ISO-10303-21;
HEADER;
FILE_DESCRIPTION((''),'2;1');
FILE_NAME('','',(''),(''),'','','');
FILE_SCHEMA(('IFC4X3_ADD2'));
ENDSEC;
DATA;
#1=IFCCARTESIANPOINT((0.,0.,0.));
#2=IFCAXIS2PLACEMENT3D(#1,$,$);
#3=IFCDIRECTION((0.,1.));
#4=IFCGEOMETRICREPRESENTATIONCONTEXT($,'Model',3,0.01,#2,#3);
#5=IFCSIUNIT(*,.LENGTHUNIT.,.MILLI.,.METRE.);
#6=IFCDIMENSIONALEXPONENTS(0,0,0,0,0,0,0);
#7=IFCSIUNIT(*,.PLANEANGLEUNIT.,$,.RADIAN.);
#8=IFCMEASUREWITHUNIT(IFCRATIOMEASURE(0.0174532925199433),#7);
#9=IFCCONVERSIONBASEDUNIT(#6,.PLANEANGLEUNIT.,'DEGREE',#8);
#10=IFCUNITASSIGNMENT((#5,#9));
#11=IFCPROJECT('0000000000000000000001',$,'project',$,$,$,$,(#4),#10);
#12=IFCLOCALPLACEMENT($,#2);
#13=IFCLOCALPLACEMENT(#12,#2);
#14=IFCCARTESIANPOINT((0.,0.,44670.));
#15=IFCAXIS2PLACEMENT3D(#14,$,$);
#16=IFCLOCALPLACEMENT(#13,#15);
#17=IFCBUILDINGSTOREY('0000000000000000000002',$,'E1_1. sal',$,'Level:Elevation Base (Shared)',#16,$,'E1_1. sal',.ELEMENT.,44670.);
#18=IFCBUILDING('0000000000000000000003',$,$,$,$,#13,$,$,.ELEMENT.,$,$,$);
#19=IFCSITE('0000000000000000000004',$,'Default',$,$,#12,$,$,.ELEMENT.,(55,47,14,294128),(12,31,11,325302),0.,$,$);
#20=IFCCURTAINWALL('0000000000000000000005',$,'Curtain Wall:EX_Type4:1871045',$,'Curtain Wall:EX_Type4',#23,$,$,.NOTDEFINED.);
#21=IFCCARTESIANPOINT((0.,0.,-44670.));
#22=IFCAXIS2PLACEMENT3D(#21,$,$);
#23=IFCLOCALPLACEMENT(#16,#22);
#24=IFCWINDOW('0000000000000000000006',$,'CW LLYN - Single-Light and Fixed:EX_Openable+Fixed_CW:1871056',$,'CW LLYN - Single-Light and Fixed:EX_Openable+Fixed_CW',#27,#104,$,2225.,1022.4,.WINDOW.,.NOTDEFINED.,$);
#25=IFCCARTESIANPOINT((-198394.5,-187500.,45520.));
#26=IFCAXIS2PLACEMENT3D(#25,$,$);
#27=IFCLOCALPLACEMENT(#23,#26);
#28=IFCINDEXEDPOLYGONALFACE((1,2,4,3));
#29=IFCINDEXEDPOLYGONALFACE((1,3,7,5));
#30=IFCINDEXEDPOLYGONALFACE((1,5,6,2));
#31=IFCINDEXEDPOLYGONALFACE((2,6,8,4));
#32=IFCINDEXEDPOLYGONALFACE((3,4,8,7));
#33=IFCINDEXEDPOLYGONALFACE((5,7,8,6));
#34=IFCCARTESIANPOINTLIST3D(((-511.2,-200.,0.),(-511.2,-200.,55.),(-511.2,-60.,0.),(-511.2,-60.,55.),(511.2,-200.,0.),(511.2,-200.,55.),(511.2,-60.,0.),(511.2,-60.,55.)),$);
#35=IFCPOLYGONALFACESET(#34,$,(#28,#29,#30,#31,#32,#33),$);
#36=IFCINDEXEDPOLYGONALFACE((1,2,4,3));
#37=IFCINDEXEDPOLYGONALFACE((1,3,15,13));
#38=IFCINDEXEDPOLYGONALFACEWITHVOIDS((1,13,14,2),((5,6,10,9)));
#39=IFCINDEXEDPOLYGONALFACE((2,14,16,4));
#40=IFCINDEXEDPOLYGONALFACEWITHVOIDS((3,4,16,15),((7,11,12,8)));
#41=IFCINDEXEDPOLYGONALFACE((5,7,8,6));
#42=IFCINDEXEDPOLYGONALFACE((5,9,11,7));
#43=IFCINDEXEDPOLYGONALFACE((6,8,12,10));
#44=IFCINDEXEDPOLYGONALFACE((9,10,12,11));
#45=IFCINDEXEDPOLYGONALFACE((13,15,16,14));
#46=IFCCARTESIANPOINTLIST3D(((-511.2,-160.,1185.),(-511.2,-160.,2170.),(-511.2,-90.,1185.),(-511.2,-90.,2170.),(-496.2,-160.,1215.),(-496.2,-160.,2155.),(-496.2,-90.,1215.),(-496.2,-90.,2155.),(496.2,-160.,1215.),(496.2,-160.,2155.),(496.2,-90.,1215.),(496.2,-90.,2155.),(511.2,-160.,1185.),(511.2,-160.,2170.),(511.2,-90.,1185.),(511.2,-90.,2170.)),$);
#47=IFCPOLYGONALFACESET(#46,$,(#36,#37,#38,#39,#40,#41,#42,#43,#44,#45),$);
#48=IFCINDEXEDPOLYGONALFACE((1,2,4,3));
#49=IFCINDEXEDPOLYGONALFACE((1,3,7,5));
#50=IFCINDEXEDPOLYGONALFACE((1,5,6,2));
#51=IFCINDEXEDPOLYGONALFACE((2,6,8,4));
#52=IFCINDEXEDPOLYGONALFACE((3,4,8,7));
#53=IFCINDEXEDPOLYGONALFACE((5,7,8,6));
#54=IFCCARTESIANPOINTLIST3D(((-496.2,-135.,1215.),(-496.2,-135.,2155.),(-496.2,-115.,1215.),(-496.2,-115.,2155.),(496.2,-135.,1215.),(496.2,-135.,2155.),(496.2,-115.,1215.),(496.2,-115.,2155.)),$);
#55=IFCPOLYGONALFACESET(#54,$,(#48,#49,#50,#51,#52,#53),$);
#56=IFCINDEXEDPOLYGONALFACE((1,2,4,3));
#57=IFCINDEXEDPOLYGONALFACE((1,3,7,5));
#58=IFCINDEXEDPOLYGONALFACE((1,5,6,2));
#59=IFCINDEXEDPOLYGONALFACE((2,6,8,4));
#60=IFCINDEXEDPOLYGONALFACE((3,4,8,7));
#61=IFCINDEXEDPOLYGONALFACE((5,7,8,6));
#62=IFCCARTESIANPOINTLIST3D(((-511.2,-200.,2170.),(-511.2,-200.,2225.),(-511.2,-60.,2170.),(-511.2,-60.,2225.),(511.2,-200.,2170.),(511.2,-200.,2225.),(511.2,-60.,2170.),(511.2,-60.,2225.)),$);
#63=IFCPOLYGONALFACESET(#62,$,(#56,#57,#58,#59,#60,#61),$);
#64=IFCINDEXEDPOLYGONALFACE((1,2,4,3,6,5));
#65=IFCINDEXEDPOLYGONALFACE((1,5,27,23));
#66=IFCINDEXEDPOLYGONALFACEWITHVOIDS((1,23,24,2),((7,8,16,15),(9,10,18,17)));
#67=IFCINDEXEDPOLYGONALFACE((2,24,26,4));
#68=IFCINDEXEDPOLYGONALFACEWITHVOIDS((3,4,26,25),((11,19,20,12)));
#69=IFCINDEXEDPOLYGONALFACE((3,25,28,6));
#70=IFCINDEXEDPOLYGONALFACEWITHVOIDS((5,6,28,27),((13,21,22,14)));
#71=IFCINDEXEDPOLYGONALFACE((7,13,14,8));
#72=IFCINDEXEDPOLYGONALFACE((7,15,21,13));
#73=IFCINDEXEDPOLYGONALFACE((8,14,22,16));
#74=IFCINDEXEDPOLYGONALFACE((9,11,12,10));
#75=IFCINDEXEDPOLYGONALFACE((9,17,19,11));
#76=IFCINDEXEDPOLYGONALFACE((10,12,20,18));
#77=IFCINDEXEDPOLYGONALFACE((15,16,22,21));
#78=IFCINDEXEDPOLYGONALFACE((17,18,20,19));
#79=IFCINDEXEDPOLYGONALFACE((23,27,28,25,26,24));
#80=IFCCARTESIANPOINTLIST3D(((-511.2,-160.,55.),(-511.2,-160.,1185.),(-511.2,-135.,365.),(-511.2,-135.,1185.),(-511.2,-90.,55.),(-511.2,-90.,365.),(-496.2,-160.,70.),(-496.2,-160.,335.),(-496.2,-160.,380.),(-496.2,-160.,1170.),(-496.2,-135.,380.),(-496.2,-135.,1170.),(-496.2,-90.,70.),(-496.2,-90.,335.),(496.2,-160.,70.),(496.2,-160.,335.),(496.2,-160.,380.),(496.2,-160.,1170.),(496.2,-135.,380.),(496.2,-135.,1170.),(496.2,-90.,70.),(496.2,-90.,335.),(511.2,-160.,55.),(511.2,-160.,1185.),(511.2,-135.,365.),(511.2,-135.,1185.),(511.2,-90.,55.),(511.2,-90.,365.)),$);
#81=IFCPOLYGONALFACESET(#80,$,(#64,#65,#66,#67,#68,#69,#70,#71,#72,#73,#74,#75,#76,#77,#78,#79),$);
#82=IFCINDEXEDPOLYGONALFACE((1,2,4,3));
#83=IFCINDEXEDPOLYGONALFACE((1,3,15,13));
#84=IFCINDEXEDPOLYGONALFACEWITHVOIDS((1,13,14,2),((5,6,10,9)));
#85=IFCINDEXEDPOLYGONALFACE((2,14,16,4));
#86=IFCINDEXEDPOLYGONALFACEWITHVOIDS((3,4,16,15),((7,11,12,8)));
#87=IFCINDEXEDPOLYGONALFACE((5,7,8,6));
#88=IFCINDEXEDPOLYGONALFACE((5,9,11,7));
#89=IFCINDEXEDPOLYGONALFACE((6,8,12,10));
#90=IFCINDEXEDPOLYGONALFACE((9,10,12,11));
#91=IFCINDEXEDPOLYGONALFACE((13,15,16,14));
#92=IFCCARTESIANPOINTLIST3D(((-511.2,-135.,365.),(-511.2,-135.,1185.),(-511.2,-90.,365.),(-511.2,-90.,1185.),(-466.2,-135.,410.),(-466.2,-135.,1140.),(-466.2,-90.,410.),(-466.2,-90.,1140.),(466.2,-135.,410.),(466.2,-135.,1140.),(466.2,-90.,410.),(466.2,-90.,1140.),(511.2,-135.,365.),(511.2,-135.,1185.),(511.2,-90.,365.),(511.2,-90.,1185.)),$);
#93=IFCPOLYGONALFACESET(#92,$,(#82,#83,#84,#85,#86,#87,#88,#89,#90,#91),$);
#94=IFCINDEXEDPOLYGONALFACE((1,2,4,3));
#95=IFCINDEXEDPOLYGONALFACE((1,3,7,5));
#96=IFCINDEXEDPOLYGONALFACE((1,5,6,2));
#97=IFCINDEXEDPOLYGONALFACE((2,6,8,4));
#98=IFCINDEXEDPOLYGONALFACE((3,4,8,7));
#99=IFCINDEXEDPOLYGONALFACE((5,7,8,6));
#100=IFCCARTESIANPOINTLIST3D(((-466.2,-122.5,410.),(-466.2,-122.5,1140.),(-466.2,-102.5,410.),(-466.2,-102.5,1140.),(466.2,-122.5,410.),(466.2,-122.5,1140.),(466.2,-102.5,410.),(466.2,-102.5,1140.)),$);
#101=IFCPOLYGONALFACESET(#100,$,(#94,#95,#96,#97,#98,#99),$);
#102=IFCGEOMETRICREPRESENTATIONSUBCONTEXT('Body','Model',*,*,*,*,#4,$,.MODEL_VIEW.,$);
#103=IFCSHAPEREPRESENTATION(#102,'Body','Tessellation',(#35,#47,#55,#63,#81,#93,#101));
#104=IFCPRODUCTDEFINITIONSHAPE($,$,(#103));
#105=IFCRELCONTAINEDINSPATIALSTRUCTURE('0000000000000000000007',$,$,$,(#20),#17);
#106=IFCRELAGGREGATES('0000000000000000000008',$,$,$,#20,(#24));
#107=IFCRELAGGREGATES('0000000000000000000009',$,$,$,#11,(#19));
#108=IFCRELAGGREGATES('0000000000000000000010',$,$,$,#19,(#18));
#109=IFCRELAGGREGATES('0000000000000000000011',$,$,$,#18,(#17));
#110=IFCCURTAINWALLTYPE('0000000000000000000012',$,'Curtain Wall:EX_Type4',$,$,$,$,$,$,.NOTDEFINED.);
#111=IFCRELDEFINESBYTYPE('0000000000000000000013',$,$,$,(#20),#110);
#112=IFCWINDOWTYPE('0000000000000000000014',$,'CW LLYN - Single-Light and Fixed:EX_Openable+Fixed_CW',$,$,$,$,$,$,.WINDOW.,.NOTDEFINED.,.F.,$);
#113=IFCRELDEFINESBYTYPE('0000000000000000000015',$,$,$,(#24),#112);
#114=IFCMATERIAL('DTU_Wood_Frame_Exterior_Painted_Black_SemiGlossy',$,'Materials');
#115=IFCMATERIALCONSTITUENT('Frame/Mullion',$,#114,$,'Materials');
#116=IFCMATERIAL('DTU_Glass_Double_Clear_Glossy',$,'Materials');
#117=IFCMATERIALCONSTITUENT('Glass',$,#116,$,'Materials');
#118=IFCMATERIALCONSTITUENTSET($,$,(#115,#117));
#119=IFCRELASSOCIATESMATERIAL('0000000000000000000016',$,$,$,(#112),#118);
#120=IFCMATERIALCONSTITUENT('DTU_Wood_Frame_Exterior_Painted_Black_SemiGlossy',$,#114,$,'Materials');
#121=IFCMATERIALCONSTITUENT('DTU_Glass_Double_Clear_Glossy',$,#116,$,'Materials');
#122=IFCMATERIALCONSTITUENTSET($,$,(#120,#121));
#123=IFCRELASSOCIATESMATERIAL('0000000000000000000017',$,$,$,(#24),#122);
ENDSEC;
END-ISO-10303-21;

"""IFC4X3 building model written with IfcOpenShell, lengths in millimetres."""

from ifc_helpers import new_model, entity, si_unit, converted_unit, direction, frame, frame_2d, origin, origin_2d_with_axis, place, context, subcontext, project, spatial, polyline, rectangle, outline, extrude, source, transform, mapped, material, constituent, constituent_set, type_object, type_shapes, element, aggregate, save


model = new_model("IFC4X3")

# Units and contexts
model_context = context("Model", 3, precision=0.01, world=origin(), true_north=direction((0.0, 1.0)))
body_context = subcontext(model_context, "Body", "Model", "MODEL_VIEW")
ifc_project = project(units=[si_unit("LENGTHUNIT", "METRE", prefix="MILLI"), converted_unit("PLANEANGLEUNIT", "DEGREE", entity("IfcRatioMeasure", 0.0174532925199433), si_unit("PLANEANGLEUNIT", "RADIAN"), dimensions=[0, 0, 0, 0, 0, 0, 0])], contexts=[model_context])

# Site, building, storey
site_placement = place(None, origin())
site = spatial("IfcSite", under=ifc_project, at=site_placement, Name="Default", CompositionType="ELEMENT", RefLatitude=(55, 47, 14, 294128), RefLongitude=(12, 31, 11, 325302), RefElevation=0.0)
building_placement = place(site_placement, origin())
building = spatial("IfcBuilding", under=site, at=building_placement, CompositionType="ELEMENT")
storey_placement = place(building_placement, frame((0.0, 0.0, 44670.0)))
storey = spatial("IfcBuildingStorey", under=building, at=storey_placement, Name="E1_1. sal", ObjectType="Level:Elevation Base (Shared)", LongName="E1_1. sal", CompositionType="ELEMENT", Elevation=44670.0)

# Curtain wall
curtain_wall_type_1 = type_object("IfcCurtainWallType", Name="Curtain Wall:EX_Type4", PredefinedType="NOTDEFINED")
curtain_wall_1_placement = place(storey_placement, frame((0.0, 0.0, -44670.0)))
curtain_wall_1 = element("IfcCurtainWall", 1, at=curtain_wall_1_placement, inside=storey, type_object=curtain_wall_type_1, Name="Curtain Wall:EX_Type4:1871045", ObjectType="Curtain Wall:EX_Type4", PredefinedType="NOTDEFINED")

# Shared definitions
ifc_material_1 = material(Name="DTU_Wood_Frame_Exterior_Painted_Black_SemiGlossy", Category="Materials")
ifc_material_2 = material(Name="DTU_Glass_Double_Clear_Glossy", Category="Materials")

# Window, openings
ifc_constituent_1 = constituent(ifc_material_1, Name="DTU_Wood_Frame_Exterior_Painted_Black_SemiGlossy", Category="Materials")
ifc_constituent_2 = constituent(ifc_material_2, Name="DTU_Glass_Double_Clear_Glossy", Category="Materials")
ifc_constituent_set_1 = constituent_set(constituents=[ifc_constituent_1, ifc_constituent_2])
ifc_constituent_3 = constituent(ifc_material_1, Name="Frame/Mullion", Category="Materials")
ifc_constituent_4 = constituent(ifc_material_2, Name="Glass", Category="Materials")
ifc_constituent_set_2 = constituent_set(constituents=[ifc_constituent_3, ifc_constituent_4])
window_type_1 = type_object("IfcWindowType", Name="CW LLYN - Single-Light and Fixed:EX_Openable+Fixed_CW", ParameterTakesPrecedence=False, PartitioningType="NOTDEFINED", PredefinedType="WINDOW", material=ifc_constituent_set_2)
shared_shape_1 = source(origin(), body_context, "Body", "SweptSolid", [
    extrude(rectangle(XDim=140.0, YDim=1022.4, at=origin_2d_with_axis()), frame((0.0, -130.0, 0.0), z_axis=(0.0, 0.0, 1.0), x_axis=(0.0, -1.0, 0.0)), (0.0, 0.0, 1.0), 55.0),
    extrude(outline(polyline([(-492.5, -511.2), (492.5, -511.2), (492.5, 511.2), (-492.5, 511.2), (-492.5, -511.2)]), holes=[polyline([(477.5, -496.2), (-462.5, -496.2), (-462.5, 496.2), (477.5, 496.2), (477.5, -496.2)])]), frame((0.0, -90.0, 1677.5), z_axis=(0.0, -1.0, 0.0), x_axis=(0.0, 0.0, 1.0)), (0.0, 0.0, 1.0), 70.0),
    extrude(rectangle(XDim=992.4, YDim=20.0, at=frame_2d((0.0, 0.0), x_axis=(1.0, 0.0))), frame((0.0, -125.0, 1215.0), z_axis=(0.0, 0.0, 1.0), x_axis=(-1.0, 0.0, 0.0)), (0.0, 0.0, 1.0), 940.0),
    extrude(rectangle(XDim=992.4, YDim=20.0, at=frame_2d((0.0, 0.0), x_axis=(1.0, 0.0))), frame((0.0, -125.0, 70.0), z_axis=(0.0, 0.0, 1.0), x_axis=(-1.0, 0.0, 0.0)), (0.0, 0.0, 1.0), 265.0),
    extrude(rectangle(XDim=140.0, YDim=1022.4, at=frame_2d((0.0, 0.0), x_axis=(1.0, 0.0))), frame((0.0, -130.0, 2170.0), z_axis=(0.0, 0.0, 1.0), x_axis=(0.0, -1.0, 0.0)), (0.0, 0.0, 1.0), 55.0),
    extrude(outline(polyline([(-38.3, -480.0), (31.7, -480.0), (31.7, 650.0), (6.7, 650.0), (6.7, -170.0), (-38.3, -170.0), (-38.3, -480.0)])), frame((511.2, -128.3, 535.0), z_axis=(-1.0, 0.0, 0.0), x_axis=(0.0, -1.0, 0.0)), (0.0, 0.0, 1.0), 1022.4),
    extrude(outline(polyline([(-410.0, -511.2), (410.0, -511.2), (410.0, 511.2), (-410.0, 511.2), (-410.0, -511.2)]), holes=[polyline([(-365.0, 466.2), (365.0, 466.2), (365.0, -466.2), (-365.0, -466.2), (-365.0, 466.2)])]), frame((0.0, -90.0, 775.0), z_axis=(0.0, -1.0, 0.0), x_axis=(0.0, 0.0, 1.0)), (0.0, 0.0, 1.0), 45.0),
    extrude(rectangle(XDim=932.4, YDim=20.0, at=frame_2d((0.0, 0.0), x_axis=(1.0, 0.0))), frame((0.0, -112.5, 410.0), z_axis=(0.0, 0.0, 1.0), x_axis=(-1.0, 0.0, 0.0)), (0.0, 0.0, 1.0), 730.0),
])
type_shapes(window_type_1, [shared_shape_1])
window_1_placement = place(curtain_wall_1_placement, frame((-198394.5, -187500.0, 45520.0)))
window_1 = element("IfcWindow", 2, at=window_1_placement, type_object=window_type_1, material=ifc_constituent_set_1, Name="CW LLYN - Single-Light and Fixed:EX_Openable+Fixed_CW:1871056", ObjectType="CW LLYN - Single-Light and Fixed:EX_Openable+Fixed_CW", OverallHeight=2225.0, OverallWidth=1022.4, PartitioningType="NOTDEFINED", PredefinedType="WINDOW", context=body_context, shape_type="MappedRepresentation", body=[
    mapped(shared_shape_1, transform((0.0, 0.0, 0.0), scale=1.0)),
])
opening_1_placement = place(curtain_wall_1_placement, frame((-198394.5, -187500.0, 90190.0), z_axis=(0.0, 0.0, 1.0), x_axis=(-1.0, 0.0, 0.0)))
opening_1 = element("IfcOpeningElement", 3, at=opening_1_placement, cuts=window_1, PredefinedType="OPENING", context=body_context, shape_type="SweptSolid", body=[
    extrude(rectangle(XDim=265.0, YDim=992.4, at=frame_2d((0.0, 0.0), x_axis=(1.0, 0.0))), frame((0.0, 160.0, -44467.5), z_axis=(0.0, -1.0, 0.0), x_axis=(0.0, 0.0, 1.0)), (0.0, 0.0, 1.0), 70.0),
])
opening_2_placement = place(curtain_wall_1_placement, frame((-198394.5, -187500.0, 90190.0), z_axis=(0.0, 0.0, 1.0), x_axis=(-1.0, 0.0, 0.0)))
opening_2 = element("IfcOpeningElement", 4, at=opening_2_placement, cuts=window_1, PredefinedType="OPENING", context=body_context, shape_type="SweptSolid", body=[
    extrude(rectangle(XDim=790.0, YDim=992.4, at=frame_2d((0.0, 0.0), x_axis=(1.0, 0.0))), frame((0.0, 135.0, -43895.0), z_axis=(0.0, 1.0, 0.0), x_axis=(0.0, 0.0, 1.0)), (0.0, 0.0, 1.0), 25.0),
])
aggregate(curtain_wall_1, [window_1, opening_1, opening_2])

save(model, "model.ifc")
